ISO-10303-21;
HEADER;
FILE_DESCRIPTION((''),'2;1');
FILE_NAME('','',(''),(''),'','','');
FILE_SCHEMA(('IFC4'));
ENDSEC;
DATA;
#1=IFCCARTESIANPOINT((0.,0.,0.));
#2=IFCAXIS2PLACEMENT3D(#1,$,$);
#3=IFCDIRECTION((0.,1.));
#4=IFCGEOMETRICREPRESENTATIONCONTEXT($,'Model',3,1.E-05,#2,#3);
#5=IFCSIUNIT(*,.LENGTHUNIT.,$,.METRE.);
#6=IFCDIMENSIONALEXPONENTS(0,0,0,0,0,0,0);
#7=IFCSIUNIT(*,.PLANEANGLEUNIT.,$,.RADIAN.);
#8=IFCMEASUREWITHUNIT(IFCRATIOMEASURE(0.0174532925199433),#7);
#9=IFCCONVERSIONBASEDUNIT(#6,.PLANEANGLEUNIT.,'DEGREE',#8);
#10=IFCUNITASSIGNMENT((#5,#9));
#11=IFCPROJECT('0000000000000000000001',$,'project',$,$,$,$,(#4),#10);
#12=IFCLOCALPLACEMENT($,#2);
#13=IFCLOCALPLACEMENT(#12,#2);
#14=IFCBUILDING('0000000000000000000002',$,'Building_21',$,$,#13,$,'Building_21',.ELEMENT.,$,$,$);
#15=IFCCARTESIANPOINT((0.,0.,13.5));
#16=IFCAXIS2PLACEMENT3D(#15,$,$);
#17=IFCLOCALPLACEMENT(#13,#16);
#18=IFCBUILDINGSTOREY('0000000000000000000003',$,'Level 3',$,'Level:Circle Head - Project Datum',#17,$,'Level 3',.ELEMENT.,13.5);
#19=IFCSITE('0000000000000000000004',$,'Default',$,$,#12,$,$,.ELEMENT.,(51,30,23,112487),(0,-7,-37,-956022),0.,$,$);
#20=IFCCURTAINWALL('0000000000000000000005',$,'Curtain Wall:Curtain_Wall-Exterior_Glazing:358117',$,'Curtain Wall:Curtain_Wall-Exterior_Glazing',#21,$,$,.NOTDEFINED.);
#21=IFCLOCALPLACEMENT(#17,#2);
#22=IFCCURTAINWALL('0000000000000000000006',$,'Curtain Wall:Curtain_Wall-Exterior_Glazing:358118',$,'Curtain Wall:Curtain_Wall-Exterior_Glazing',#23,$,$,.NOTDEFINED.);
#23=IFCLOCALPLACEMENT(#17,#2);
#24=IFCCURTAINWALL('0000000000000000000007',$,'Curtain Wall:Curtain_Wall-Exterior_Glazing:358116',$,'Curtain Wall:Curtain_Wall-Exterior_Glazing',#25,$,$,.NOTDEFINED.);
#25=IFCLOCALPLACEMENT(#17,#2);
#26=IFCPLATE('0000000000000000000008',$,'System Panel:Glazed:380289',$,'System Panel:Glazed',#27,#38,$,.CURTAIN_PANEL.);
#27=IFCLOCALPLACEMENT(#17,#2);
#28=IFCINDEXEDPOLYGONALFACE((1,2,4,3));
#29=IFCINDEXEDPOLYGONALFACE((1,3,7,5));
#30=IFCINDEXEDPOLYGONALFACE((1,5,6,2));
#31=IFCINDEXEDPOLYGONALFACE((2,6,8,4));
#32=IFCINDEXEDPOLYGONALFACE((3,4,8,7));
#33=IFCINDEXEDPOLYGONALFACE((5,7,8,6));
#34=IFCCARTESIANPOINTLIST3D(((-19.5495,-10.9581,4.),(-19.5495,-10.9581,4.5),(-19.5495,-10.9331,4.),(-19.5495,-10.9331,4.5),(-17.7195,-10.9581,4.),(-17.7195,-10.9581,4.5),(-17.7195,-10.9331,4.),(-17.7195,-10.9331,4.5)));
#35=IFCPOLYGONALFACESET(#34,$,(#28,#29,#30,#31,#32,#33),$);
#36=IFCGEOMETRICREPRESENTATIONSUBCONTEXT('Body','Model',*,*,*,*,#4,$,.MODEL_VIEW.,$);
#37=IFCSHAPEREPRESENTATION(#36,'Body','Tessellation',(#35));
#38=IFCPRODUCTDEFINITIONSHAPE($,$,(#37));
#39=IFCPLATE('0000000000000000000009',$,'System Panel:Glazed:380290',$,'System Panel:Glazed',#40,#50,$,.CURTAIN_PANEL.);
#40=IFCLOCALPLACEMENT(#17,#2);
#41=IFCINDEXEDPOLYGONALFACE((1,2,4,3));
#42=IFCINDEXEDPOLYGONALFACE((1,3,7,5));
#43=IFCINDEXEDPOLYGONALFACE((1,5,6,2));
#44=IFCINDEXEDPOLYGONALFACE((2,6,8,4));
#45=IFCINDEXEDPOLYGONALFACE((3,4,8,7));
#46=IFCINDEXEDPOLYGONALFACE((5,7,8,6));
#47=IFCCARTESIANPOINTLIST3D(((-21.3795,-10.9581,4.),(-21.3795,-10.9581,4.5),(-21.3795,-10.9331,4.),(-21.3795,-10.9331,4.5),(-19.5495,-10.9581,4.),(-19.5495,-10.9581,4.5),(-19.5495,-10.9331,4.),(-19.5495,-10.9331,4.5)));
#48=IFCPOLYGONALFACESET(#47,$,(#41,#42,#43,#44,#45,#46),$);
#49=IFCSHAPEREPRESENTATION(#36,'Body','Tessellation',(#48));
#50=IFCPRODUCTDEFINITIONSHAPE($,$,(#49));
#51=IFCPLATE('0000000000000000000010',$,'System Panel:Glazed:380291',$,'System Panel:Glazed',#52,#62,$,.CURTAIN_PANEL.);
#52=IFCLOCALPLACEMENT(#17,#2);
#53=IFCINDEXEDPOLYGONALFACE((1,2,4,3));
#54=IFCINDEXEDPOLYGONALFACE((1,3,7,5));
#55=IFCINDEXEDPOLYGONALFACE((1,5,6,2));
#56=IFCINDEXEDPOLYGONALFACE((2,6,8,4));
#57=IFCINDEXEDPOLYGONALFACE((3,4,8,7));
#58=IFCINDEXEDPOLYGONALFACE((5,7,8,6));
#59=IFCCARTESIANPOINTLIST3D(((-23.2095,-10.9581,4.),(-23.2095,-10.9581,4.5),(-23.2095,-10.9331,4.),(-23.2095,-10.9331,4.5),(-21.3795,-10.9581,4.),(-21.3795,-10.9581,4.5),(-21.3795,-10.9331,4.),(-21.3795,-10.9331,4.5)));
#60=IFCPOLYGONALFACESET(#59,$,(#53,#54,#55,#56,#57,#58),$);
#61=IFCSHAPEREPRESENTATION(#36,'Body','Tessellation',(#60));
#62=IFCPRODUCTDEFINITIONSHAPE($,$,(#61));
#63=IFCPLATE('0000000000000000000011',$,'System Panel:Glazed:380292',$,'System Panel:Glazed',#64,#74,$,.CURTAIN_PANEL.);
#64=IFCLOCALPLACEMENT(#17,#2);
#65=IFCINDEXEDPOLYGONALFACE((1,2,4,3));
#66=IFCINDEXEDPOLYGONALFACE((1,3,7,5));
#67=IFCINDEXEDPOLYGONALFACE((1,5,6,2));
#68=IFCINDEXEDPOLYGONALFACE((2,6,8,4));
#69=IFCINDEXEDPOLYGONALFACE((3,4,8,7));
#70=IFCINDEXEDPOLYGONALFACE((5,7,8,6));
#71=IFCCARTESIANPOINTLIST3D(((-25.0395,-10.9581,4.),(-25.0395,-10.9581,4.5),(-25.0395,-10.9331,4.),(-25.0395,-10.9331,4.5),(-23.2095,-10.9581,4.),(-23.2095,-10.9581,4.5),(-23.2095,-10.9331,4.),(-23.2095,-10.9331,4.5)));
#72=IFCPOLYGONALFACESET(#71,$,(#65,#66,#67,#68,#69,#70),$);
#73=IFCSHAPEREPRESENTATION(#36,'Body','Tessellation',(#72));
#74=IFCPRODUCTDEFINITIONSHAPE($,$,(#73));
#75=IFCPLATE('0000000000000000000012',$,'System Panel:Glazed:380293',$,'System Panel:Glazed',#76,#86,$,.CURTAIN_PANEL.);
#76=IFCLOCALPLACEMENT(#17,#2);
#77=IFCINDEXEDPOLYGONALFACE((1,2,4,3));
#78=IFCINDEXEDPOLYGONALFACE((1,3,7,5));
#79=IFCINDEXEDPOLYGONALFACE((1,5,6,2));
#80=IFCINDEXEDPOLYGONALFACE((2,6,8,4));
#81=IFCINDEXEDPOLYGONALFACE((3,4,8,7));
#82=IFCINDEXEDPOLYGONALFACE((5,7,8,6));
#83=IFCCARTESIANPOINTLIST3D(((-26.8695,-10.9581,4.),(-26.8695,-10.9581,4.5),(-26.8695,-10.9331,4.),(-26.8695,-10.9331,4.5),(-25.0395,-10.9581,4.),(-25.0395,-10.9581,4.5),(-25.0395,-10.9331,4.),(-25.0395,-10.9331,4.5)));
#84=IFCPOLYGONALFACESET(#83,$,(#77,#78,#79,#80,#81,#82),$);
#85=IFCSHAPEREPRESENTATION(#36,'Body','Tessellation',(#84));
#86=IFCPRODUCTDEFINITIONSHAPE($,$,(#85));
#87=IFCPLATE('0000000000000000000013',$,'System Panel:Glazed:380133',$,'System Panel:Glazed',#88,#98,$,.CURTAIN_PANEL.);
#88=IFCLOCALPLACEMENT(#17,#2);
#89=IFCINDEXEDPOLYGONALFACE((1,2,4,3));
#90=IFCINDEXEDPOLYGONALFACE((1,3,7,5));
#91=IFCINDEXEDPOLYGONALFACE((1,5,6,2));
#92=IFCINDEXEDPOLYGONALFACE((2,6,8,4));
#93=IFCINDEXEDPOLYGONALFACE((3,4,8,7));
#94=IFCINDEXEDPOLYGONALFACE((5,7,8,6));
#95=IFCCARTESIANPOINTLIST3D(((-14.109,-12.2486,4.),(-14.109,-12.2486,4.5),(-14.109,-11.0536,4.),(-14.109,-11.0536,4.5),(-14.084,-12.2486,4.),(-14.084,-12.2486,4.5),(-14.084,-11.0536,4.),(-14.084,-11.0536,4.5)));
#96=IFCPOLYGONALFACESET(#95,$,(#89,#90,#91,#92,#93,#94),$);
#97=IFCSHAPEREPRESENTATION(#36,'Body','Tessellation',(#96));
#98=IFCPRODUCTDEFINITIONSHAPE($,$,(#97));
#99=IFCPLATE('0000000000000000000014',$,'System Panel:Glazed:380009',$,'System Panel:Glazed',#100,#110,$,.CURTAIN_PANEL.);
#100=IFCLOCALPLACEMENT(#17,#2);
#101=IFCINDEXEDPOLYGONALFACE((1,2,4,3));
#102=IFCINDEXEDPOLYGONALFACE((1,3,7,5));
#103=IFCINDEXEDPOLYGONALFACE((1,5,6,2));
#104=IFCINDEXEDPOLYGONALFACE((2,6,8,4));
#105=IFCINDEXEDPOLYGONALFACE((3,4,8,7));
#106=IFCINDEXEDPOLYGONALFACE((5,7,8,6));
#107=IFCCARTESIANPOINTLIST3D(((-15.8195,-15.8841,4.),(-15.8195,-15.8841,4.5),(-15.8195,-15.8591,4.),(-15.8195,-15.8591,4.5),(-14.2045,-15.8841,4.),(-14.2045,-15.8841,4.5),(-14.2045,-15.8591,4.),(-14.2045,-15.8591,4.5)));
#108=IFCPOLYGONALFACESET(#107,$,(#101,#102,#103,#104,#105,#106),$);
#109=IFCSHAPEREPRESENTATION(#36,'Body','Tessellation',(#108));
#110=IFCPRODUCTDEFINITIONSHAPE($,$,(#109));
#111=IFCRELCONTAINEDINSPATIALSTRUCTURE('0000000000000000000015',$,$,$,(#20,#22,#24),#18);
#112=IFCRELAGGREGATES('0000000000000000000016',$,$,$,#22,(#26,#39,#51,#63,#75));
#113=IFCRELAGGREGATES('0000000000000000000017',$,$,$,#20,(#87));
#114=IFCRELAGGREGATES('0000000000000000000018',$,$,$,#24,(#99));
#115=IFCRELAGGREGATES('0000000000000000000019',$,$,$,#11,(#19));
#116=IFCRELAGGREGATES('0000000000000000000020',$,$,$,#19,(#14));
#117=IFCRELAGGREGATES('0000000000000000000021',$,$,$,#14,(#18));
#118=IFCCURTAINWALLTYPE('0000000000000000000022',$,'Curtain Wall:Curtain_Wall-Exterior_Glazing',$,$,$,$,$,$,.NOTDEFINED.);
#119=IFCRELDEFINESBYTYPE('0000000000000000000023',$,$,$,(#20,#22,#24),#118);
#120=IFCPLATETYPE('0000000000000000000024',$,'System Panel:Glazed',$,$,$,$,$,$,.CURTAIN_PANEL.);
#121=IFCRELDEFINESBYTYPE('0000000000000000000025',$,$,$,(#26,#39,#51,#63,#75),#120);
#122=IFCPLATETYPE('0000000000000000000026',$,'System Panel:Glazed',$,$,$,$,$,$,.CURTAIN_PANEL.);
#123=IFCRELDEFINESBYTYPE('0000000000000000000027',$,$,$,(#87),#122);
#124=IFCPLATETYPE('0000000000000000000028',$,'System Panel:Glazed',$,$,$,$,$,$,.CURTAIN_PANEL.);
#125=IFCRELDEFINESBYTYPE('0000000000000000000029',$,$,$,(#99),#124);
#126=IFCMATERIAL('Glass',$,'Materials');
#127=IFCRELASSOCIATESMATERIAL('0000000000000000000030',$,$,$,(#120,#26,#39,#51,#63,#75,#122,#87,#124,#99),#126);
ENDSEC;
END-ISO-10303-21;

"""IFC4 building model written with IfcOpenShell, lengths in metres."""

from ifc_helpers import new_model, entity, si_unit, converted_unit, direction, frame, origin, origin_2d_with_axis, place, context, subcontext, project, spatial, rectangle, extrude, source, transform, mapped, material, type_object, type_shapes, element, aggregate, save


model = new_model("IFC4")

# Units and contexts
model_context = context("Model", 3, precision=1e-05, world=origin(), true_north=direction((0.0, 1.0)))
body_context = subcontext(model_context, "Body", "Model", "MODEL_VIEW")
ifc_project = project(units=[si_unit("LENGTHUNIT", "METRE"), converted_unit("PLANEANGLEUNIT", "DEGREE", entity("IfcRatioMeasure", 0.0174532925199433), si_unit("PLANEANGLEUNIT", "RADIAN"), dimensions=[0, 0, 0, 0, 0, 0, 0])], contexts=[model_context])

# Site, building, storey
site_placement = place(None, origin())
site = spatial("IfcSite", under=ifc_project, at=site_placement, Name="Default", CompositionType="ELEMENT", RefLatitude=(51, 30, 23, 112487), RefLongitude=(0, -7, -37, -956022), RefElevation=0.0)
building_placement = place(site_placement, origin())
building = spatial("IfcBuilding", under=site, at=building_placement, Name="Building_21", LongName="Building_21", CompositionType="ELEMENT")
storey_placement = place(building_placement, frame((0.0, 0.0, 13.5)))
storey = spatial("IfcBuildingStorey", under=building, at=storey_placement, Name="Level 3", ObjectType="Level:Circle Head - Project Datum", LongName="Level 3", CompositionType="ELEMENT", Elevation=13.5)

# Curtain wall
curtain_wall_type = type_object("IfcCurtainWallType", Name="Curtain Wall:Curtain_Wall-Exterior_Glazing", PredefinedType="NOTDEFINED")
curtain_wall_1_placement = place(storey_placement, frame((0.0, 0.0, -13.5)))
curtain_wall_1 = element("IfcCurtainWall", 1, at=curtain_wall_1_placement, inside=storey, type_object=curtain_wall_type, Name="Curtain Wall:Curtain_Wall-Exterior_Glazing:358117", ObjectType="Curtain Wall:Curtain_Wall-Exterior_Glazing", PredefinedType="NOTDEFINED")
ifc_material = material(Name="Glass", Category="Materials")

# Curtain wall
curtain_wall_2_placement = place(storey_placement, frame((0.0, 0.0, -13.5)))
curtain_wall_2 = element("IfcCurtainWall", 2, at=curtain_wall_2_placement, inside=storey, type_object=curtain_wall_type, Name="Curtain Wall:Curtain_Wall-Exterior_Glazing:358118", ObjectType="Curtain Wall:Curtain_Wall-Exterior_Glazing", PredefinedType="NOTDEFINED")

# Curtain wall
curtain_wall_3_placement = place(storey_placement, frame((0.0, 0.0, -13.5)))
curtain_wall_3 = element("IfcCurtainWall", 3, at=curtain_wall_3_placement, inside=storey, type_object=curtain_wall_type, Name="Curtain Wall:Curtain_Wall-Exterior_Glazing:358116", ObjectType="Curtain Wall:Curtain_Wall-Exterior_Glazing", PredefinedType="NOTDEFINED")
plate_type_1 = type_object("IfcPlateType", Name="System Panel:Glazed", PredefinedType="CURTAIN_PANEL", material=ifc_material)
shared_shape_1 = source(origin(), body_context, "Body", "SweptSolid", [
    extrude(rectangle(XDim=0.025, YDim=1.83, at=origin_2d_with_axis()), frame((0.915, 0.0125, 0.0), z_axis=(0.0, 0.0, 1.0), x_axis=(0.0, 1.0, 0.0)), (0.0, 0.0, 1.0), 0.5),
])
type_shapes(plate_type_1, [shared_shape_1])

# Plates
plate_1_placement = place(curtain_wall_2_placement, frame((-17.7195, -10.9331, 17.5), z_axis=(0.0, 0.0, 1.0), x_axis=(-1.0, 0.0, 0.0)))
plate_1 = element("IfcPlate", 4, at=plate_1_placement, type_object=plate_type_1, material=ifc_material, Name="System Panel:Glazed:380289", ObjectType="System Panel:Glazed", PredefinedType="CURTAIN_PANEL", context=body_context, shape_type="MappedRepresentation", body=[
    mapped(shared_shape_1, transform((0.0, 0.0, 0.0), scale=1.0)),
])
plate_2_placement = place(curtain_wall_2_placement, frame((-19.5495, -10.9331, 17.5), z_axis=(0.0, 0.0, 1.0), x_axis=(-1.0, 0.0, 0.0)))
plate_2 = element("IfcPlate", 5, at=plate_2_placement, type_object=plate_type_1, material=ifc_material, Name="System Panel:Glazed:380290", ObjectType="System Panel:Glazed", PredefinedType="CURTAIN_PANEL", context=body_context, shape_type="MappedRepresentation", body=[
    mapped(shared_shape_1, transform((0.0, 0.0, 0.0), scale=1.0)),
])
plate_3_placement = place(curtain_wall_2_placement, frame((-21.3795, -10.9331, 17.5), z_axis=(0.0, 0.0, 1.0), x_axis=(-1.0, 0.0, 0.0)))
plate_3 = element("IfcPlate", 6, at=plate_3_placement, type_object=plate_type_1, material=ifc_material, Name="System Panel:Glazed:380291", ObjectType="System Panel:Glazed", PredefinedType="CURTAIN_PANEL", context=body_context, shape_type="MappedRepresentation", body=[
    mapped(shared_shape_1, transform((0.0, 0.0, 0.0), scale=1.0)),
])
plate_4_placement = place(curtain_wall_2_placement, frame((-23.2095, -10.9331, 17.5), z_axis=(0.0, 0.0, 1.0), x_axis=(-1.0, 0.0, 0.0)))
plate_4 = element("IfcPlate", 7, at=plate_4_placement, type_object=plate_type_1, material=ifc_material, Name="System Panel:Glazed:380292", ObjectType="System Panel:Glazed", PredefinedType="CURTAIN_PANEL", context=body_context, shape_type="MappedRepresentation", body=[
    mapped(shared_shape_1, transform((0.0, 0.0, 0.0), scale=1.0)),
])
plate_5_placement = place(curtain_wall_2_placement, frame((-25.0395, -10.9331, 17.5), z_axis=(0.0, 0.0, 1.0), x_axis=(-1.0, 0.0, 0.0)))
plate_5 = element("IfcPlate", 8, at=plate_5_placement, type_object=plate_type_1, material=ifc_material, Name="System Panel:Glazed:380293", ObjectType="System Panel:Glazed", PredefinedType="CURTAIN_PANEL", context=body_context, shape_type="MappedRepresentation", body=[
    mapped(shared_shape_1, transform((0.0, 0.0, 0.0), scale=1.0)),
])
aggregate(curtain_wall_2, [plate_1, plate_2, plate_3, plate_4, plate_5])
plate_type_2 = type_object("IfcPlateType", Name="System Panel:Glazed", PredefinedType="CURTAIN_PANEL", material=ifc_material)
shared_shape_2 = source(origin(), body_context, "Body", "SweptSolid", [
    extrude(rectangle(XDim=0.025, YDim=1.195, at=origin_2d_with_axis()), frame((0.5975, 0.0125, 0.0), z_axis=(0.0, 0.0, 1.0), x_axis=(0.0, 1.0, 0.0)), (0.0, 0.0, 1.0), 0.5),
])
type_shapes(plate_type_2, [shared_shape_2])
plate_6_placement = place(curtain_wall_1_placement, frame((-14.084, -12.2486, 17.5), z_axis=(0.0, 0.0, 1.0), x_axis=(0.0, 1.0, 0.0)))
plate_6 = element("IfcPlate", 9, at=plate_6_placement, type_object=plate_type_2, material=ifc_material, Name="System Panel:Glazed:380133", ObjectType="System Panel:Glazed", PredefinedType="CURTAIN_PANEL", context=body_context, shape_type="MappedRepresentation", body=[
    mapped(shared_shape_2, transform((0.0, 0.0, 0.0), scale=1.0)),
])
aggregate(curtain_wall_1, [plate_6])
plate_type_3 = type_object("IfcPlateType", Name="System Panel:Glazed", PredefinedType="CURTAIN_PANEL", material=ifc_material)
shared_shape_3 = source(origin(), body_context, "Body", "SweptSolid", [
    extrude(rectangle(XDim=0.025, YDim=1.615, at=origin_2d_with_axis()), frame((0.8075, 0.0125, 0.0), z_axis=(0.0, 0.0, 1.0), x_axis=(0.0, 1.0, 0.0)), (0.0, 0.0, 1.0), 0.5),
])
type_shapes(plate_type_3, [shared_shape_3])
plate_7_placement = place(curtain_wall_3_placement, frame((-15.8195, -15.8841, 17.5)))
plate_7 = element("IfcPlate", 10, at=plate_7_placement, type_object=plate_type_3, material=ifc_material, Name="System Panel:Glazed:380009", ObjectType="System Panel:Glazed", PredefinedType="CURTAIN_PANEL", context=body_context, shape_type="MappedRepresentation", body=[
    mapped(shared_shape_3, transform((0.0, 0.0, 0.0), scale=1.0)),
])
aggregate(curtain_wall_3, [plate_7])

save(model, "model.ifc")
